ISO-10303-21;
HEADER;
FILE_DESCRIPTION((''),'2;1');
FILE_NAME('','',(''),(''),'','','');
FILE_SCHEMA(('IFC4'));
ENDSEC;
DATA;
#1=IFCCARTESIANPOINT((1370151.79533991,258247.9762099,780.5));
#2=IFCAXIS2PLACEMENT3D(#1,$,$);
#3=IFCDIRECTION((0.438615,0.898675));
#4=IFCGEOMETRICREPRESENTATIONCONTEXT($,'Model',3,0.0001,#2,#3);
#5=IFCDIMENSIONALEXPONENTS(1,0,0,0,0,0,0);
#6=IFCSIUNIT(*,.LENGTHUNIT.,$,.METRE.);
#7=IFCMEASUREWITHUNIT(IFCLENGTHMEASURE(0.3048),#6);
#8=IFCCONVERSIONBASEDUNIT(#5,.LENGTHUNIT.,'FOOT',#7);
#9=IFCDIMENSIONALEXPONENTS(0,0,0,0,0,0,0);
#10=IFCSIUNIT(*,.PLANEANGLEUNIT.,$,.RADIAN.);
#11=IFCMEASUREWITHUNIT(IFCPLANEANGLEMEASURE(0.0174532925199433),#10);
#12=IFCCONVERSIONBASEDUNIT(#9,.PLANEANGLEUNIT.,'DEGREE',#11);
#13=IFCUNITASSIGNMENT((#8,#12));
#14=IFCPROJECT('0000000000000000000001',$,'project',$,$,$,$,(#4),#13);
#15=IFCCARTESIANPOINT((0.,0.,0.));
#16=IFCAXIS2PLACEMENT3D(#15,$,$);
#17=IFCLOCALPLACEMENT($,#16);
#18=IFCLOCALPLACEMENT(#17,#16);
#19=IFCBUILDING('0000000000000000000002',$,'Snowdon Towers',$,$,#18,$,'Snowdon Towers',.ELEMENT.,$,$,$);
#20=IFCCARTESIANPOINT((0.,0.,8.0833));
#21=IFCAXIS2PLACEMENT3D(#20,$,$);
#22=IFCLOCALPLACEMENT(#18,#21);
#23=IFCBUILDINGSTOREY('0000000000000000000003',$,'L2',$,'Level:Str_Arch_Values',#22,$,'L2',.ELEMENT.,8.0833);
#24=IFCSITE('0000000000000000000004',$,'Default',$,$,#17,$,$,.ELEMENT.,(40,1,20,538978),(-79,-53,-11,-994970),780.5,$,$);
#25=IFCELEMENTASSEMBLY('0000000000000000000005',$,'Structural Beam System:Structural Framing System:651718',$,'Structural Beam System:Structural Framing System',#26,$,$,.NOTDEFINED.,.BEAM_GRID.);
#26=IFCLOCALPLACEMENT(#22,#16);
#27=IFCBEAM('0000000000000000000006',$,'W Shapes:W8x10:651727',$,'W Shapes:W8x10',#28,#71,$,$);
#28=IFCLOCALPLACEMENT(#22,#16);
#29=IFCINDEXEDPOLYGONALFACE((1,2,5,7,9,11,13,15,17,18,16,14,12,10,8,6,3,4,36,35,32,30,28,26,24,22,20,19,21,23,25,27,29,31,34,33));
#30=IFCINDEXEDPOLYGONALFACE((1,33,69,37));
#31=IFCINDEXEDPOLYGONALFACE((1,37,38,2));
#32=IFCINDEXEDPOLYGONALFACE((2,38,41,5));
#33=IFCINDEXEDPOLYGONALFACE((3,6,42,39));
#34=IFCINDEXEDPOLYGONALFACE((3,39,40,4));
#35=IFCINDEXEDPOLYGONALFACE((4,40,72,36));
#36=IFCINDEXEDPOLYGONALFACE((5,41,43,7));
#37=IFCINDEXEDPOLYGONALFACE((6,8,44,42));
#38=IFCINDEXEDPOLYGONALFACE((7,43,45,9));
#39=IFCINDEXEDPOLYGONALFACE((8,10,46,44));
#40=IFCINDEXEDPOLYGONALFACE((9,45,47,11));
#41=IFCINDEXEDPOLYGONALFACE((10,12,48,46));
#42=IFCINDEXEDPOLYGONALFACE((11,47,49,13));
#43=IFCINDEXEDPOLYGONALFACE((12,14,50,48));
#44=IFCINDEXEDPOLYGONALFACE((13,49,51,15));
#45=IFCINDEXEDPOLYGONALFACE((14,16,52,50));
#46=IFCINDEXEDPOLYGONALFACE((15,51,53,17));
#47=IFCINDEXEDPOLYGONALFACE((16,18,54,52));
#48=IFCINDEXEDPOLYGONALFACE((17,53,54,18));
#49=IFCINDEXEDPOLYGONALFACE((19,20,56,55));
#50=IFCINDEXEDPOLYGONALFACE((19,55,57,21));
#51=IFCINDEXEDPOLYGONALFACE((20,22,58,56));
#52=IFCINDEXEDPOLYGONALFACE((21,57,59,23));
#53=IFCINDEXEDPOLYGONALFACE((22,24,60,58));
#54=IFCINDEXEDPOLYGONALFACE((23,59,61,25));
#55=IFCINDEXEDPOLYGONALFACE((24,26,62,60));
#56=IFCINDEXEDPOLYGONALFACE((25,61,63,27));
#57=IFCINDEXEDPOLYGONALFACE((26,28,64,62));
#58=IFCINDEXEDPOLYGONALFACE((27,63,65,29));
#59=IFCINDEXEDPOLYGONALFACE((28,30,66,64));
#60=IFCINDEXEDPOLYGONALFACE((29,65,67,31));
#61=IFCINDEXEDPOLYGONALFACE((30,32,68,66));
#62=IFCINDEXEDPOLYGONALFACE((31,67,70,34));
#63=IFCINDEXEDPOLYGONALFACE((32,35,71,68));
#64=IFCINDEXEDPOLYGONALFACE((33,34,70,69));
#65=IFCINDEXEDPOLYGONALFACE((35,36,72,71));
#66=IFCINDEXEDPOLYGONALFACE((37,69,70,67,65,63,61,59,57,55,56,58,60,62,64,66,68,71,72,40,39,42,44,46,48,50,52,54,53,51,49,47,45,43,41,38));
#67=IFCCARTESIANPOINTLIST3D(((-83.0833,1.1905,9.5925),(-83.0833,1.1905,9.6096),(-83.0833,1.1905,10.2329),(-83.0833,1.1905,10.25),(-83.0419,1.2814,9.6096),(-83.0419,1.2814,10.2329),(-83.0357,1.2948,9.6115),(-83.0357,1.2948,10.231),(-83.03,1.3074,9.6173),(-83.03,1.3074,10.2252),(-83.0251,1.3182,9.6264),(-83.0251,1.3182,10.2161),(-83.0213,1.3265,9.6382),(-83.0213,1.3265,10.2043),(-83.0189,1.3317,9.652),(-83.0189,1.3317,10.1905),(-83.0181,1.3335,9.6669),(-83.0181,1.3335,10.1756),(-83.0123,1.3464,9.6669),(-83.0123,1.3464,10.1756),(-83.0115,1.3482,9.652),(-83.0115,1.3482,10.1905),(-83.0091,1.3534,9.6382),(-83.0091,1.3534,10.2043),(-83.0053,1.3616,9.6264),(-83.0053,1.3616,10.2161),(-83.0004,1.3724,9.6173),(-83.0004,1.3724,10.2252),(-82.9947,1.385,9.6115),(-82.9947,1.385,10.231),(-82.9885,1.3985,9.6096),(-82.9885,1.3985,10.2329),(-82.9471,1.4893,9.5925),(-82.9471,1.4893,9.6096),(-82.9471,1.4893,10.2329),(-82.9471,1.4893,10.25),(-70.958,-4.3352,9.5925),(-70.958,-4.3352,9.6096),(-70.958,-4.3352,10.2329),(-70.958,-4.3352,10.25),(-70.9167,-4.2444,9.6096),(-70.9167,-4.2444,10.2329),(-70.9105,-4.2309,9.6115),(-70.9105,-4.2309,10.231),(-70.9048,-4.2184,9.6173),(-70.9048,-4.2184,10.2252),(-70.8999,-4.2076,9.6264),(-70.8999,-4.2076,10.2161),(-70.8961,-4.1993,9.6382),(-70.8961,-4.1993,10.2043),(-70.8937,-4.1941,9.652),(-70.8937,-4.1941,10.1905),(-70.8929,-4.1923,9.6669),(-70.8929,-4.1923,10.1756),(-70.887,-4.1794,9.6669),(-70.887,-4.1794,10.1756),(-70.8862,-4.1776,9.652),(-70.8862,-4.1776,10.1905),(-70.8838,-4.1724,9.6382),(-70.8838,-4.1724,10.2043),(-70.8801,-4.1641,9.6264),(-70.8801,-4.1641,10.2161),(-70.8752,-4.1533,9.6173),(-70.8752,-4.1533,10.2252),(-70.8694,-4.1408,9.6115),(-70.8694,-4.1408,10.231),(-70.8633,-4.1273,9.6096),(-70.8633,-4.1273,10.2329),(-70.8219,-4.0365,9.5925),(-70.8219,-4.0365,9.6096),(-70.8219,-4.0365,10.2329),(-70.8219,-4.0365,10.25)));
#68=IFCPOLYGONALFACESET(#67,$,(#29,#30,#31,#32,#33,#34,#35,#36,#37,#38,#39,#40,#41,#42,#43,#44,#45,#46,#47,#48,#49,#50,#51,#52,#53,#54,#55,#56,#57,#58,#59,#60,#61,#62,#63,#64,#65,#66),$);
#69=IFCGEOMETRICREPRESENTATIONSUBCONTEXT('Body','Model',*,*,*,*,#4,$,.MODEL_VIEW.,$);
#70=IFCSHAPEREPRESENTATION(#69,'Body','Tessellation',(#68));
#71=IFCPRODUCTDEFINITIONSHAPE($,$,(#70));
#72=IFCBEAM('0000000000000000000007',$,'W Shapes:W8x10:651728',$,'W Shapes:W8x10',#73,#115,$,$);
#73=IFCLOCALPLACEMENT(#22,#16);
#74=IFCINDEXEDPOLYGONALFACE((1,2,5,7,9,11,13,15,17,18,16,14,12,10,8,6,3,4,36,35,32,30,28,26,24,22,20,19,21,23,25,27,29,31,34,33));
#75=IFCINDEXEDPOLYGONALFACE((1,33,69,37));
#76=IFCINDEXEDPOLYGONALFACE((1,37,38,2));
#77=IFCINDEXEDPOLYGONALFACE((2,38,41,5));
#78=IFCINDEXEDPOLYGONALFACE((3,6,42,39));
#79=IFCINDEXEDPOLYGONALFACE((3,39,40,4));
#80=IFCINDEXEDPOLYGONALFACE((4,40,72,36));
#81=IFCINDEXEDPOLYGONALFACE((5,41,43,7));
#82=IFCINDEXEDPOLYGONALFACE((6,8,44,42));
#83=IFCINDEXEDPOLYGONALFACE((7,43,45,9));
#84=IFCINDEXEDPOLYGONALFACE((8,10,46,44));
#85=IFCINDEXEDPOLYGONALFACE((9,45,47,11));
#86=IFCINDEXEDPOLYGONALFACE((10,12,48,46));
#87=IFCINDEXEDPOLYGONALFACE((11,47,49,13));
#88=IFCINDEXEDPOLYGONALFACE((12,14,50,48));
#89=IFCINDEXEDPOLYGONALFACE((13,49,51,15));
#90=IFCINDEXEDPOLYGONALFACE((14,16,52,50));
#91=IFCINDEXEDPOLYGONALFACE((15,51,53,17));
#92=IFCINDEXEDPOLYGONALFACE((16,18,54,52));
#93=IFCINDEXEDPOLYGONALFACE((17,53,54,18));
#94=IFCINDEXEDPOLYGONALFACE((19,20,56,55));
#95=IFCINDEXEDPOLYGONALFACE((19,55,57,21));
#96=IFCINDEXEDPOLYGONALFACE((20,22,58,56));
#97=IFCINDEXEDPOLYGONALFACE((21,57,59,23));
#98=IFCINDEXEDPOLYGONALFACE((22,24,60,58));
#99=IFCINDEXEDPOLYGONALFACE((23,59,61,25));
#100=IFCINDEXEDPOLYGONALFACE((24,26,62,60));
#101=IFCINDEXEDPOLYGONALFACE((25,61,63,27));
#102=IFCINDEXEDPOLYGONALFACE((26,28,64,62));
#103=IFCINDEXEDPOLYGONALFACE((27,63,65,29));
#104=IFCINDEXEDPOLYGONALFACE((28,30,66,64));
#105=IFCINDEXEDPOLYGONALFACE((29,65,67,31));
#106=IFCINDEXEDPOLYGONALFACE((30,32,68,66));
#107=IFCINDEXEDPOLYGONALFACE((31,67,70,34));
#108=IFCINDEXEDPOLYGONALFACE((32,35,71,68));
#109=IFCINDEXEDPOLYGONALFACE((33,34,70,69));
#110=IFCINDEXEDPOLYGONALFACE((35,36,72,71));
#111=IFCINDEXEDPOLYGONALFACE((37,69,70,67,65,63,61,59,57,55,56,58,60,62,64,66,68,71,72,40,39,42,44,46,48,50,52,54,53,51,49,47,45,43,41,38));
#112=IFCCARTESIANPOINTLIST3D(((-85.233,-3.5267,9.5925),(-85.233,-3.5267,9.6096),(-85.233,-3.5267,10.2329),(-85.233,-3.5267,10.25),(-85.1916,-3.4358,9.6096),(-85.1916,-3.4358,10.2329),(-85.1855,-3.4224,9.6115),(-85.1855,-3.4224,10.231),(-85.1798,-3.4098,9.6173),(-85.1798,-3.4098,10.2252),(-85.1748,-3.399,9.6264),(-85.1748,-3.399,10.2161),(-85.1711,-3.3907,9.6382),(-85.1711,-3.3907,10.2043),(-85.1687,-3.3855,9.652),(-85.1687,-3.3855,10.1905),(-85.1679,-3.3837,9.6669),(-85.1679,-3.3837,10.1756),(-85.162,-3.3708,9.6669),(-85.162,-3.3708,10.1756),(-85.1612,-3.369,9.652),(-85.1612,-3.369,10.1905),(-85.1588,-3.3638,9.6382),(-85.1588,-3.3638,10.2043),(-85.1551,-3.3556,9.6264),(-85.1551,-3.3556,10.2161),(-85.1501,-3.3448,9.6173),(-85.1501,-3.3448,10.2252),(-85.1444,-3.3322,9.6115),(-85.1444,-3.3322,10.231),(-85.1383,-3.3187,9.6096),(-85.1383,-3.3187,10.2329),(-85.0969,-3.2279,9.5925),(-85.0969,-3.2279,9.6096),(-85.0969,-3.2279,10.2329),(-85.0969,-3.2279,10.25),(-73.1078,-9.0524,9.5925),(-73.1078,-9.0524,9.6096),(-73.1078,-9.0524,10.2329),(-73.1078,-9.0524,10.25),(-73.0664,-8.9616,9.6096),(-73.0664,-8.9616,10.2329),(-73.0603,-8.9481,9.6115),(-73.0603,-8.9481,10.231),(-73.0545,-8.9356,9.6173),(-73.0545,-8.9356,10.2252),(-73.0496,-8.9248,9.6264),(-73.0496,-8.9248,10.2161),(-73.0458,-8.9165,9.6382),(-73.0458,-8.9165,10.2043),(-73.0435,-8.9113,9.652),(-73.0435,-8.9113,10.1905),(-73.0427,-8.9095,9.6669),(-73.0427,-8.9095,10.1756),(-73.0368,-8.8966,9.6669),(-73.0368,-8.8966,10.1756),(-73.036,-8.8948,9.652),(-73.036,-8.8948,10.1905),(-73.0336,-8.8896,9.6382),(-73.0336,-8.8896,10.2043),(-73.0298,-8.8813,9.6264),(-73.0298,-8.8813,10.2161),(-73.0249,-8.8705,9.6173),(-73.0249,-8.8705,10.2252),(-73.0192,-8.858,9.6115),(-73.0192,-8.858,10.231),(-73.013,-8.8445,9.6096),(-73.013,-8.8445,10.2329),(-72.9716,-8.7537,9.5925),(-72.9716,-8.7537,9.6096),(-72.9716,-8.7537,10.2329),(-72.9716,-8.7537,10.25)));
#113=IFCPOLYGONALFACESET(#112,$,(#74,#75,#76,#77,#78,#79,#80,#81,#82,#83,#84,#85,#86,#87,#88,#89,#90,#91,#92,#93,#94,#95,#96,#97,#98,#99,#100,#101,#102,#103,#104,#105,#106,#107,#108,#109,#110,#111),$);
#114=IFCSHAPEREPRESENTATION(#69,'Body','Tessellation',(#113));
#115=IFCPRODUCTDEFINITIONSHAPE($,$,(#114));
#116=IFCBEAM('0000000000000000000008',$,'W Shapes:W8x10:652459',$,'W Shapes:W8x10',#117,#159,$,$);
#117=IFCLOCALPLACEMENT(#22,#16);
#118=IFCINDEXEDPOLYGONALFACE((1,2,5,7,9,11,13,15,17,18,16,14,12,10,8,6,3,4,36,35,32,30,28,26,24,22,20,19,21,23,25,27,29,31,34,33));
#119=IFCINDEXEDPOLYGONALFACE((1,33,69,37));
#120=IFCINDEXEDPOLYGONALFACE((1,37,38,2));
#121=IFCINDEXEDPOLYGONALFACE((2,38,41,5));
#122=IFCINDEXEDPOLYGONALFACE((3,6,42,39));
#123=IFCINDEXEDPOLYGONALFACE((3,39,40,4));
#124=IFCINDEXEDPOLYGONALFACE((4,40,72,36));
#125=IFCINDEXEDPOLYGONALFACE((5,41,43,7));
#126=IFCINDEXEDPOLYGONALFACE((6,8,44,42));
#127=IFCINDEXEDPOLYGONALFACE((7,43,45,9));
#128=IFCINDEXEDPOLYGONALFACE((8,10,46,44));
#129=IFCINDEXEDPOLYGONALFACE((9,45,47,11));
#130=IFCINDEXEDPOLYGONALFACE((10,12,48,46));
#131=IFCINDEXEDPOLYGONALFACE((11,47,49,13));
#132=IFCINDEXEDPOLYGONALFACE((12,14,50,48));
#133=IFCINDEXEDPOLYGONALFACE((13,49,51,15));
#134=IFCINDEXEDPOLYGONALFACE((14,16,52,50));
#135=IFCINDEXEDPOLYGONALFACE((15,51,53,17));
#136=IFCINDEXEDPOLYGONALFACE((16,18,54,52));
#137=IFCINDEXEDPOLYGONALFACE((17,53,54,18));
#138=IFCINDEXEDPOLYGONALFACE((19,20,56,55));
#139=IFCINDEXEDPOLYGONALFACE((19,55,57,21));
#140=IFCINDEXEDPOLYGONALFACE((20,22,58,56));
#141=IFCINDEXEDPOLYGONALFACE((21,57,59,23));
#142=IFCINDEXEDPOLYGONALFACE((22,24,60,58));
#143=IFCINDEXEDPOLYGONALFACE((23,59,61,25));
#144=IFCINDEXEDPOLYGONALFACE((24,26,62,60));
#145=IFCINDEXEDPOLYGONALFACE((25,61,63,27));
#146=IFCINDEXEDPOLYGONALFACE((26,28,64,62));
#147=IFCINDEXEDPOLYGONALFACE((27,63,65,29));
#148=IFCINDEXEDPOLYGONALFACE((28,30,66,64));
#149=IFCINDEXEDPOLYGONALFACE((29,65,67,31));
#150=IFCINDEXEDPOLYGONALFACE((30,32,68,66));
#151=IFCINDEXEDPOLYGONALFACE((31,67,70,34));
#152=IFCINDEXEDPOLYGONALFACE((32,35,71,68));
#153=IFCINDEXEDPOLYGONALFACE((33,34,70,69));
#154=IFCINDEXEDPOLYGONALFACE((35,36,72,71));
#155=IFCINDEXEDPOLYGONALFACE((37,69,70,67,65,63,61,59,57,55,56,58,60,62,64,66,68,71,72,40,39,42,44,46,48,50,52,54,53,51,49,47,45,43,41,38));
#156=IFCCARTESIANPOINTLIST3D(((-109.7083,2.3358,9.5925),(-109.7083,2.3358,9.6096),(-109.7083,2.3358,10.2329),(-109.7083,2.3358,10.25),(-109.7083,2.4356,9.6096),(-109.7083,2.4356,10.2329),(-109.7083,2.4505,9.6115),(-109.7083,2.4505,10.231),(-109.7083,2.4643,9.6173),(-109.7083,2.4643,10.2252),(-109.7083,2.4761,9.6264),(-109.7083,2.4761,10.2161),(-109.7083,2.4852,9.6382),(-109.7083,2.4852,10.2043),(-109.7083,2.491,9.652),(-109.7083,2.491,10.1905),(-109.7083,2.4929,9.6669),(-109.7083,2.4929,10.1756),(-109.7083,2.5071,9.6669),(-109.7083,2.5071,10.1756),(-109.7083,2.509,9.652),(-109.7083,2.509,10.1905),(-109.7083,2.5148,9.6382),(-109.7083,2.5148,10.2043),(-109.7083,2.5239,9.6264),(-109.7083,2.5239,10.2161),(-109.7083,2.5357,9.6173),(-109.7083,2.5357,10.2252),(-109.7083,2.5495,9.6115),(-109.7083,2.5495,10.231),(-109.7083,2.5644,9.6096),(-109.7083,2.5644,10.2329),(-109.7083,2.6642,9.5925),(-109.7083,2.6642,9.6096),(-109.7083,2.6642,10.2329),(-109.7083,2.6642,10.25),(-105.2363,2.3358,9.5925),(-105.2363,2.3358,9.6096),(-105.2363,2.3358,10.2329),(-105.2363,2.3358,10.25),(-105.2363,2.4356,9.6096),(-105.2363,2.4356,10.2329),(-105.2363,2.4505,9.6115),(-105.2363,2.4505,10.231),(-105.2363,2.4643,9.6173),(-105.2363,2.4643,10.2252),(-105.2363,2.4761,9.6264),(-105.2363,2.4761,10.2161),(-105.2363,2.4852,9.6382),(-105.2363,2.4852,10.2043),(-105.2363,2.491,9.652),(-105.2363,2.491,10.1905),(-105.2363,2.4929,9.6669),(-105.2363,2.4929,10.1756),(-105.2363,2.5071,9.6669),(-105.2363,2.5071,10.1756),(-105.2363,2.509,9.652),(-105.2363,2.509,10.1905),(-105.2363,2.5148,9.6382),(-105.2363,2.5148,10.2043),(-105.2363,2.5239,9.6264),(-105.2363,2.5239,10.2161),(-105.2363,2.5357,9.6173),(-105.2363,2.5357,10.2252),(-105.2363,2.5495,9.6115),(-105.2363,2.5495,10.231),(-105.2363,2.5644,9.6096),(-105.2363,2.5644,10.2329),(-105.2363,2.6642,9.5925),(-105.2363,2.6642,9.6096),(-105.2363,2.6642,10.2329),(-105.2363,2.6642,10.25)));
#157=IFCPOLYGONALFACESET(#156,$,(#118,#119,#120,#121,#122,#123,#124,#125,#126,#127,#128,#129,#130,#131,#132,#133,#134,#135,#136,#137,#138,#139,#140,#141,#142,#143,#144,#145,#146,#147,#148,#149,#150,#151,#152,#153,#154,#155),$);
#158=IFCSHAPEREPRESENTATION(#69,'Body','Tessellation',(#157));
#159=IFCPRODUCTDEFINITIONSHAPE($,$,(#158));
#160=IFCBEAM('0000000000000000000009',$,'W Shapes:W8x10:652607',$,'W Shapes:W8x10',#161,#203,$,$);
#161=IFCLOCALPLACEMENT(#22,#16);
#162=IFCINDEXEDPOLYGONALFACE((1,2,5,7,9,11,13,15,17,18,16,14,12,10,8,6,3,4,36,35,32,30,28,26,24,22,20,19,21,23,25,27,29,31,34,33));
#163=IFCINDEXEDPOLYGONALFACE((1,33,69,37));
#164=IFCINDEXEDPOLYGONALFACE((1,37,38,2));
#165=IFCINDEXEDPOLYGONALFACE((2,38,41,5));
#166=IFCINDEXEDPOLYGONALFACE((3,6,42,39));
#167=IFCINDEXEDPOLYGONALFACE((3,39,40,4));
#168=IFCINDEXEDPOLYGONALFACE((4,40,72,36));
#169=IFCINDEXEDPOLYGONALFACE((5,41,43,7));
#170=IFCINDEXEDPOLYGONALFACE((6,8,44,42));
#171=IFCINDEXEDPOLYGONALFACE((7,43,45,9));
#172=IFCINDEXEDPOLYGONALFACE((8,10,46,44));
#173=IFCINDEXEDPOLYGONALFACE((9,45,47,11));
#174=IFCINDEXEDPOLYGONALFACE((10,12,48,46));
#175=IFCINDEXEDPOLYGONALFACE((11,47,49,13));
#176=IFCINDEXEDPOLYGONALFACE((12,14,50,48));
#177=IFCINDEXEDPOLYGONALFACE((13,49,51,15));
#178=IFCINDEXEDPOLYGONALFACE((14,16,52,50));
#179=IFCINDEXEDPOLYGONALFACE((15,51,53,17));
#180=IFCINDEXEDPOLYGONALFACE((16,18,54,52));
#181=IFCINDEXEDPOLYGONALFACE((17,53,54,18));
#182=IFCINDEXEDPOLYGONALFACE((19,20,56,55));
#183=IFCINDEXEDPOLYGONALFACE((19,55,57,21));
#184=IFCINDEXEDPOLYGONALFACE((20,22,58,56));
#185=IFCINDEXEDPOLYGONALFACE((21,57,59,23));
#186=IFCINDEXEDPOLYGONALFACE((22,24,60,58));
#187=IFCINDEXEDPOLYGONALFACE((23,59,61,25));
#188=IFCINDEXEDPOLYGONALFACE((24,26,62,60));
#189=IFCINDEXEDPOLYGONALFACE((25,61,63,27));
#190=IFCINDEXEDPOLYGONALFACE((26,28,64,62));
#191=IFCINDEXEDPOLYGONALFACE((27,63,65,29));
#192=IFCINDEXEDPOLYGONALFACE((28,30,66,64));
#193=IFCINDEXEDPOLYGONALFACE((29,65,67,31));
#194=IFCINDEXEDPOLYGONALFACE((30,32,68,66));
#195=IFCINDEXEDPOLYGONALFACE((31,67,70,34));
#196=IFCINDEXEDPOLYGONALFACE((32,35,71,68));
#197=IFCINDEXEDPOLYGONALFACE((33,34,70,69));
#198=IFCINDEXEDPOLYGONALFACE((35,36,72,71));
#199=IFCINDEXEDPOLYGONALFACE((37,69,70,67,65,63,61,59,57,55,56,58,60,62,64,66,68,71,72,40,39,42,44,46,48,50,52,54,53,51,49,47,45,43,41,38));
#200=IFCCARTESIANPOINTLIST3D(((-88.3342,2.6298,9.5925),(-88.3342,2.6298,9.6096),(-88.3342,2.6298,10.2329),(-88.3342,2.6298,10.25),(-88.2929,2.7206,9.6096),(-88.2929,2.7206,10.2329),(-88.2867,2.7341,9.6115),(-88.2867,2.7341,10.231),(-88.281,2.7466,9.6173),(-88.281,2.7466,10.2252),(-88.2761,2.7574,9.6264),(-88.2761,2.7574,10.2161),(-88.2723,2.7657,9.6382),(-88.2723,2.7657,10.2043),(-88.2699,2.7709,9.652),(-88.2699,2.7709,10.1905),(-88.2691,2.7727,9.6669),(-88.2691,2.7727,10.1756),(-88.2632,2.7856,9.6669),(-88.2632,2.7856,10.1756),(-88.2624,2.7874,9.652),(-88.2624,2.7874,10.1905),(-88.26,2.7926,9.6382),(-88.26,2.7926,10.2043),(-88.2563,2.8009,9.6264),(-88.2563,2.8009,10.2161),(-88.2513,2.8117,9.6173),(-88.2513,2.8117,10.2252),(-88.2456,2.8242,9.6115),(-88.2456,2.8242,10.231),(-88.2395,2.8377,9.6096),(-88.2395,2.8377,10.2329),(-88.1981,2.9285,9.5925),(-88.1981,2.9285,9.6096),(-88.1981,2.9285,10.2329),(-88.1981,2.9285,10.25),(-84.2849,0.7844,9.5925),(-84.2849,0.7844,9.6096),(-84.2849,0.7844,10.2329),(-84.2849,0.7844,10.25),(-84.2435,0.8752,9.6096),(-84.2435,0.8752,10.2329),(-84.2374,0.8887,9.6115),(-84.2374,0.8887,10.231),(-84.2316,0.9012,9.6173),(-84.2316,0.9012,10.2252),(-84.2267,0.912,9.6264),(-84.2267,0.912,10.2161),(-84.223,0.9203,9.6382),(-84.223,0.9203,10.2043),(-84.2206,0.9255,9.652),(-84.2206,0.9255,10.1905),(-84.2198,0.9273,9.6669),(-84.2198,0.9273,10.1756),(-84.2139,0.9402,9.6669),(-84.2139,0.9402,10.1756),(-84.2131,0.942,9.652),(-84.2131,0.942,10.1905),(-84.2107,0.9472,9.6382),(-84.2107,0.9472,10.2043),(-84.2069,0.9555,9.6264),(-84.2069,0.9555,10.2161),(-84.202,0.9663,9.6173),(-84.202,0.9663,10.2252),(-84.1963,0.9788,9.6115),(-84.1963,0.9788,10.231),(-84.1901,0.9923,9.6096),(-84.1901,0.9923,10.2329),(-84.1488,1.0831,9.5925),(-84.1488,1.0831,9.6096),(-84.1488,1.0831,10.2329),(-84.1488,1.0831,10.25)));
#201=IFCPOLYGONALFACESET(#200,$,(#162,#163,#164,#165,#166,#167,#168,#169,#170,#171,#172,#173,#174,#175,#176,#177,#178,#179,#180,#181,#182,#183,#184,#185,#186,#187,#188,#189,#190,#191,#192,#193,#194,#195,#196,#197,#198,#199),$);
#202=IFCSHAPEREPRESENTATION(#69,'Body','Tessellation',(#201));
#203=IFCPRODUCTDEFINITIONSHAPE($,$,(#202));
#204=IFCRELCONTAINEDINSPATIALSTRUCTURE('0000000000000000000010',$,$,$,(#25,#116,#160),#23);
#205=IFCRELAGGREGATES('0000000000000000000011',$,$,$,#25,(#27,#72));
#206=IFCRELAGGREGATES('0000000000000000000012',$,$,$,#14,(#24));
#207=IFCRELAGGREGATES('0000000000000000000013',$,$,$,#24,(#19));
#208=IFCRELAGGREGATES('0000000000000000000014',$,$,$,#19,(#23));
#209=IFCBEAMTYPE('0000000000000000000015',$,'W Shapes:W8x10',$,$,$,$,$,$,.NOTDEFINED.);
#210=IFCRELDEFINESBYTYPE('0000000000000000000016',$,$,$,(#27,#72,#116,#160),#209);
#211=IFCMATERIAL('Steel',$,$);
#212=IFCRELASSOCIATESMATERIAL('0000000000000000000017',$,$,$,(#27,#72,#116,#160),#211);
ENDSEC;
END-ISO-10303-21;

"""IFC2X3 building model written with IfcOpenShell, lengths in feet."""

from ifc_helpers import new_model, entity, si_unit, converted_unit, direction, frame, frame_2d, origin, place, context, subcontext, project, spatial, i_section, extrude, material, type_object, element, aggregate, save


model = new_model("IFC2X3")

# Units and contexts
model_context = context("Model", 3, precision=0.0001, world=frame((1370151.79533991, 258247.9762099, 780.5)), true_north=direction((0.438615, 0.898675)))
body_context = subcontext(model_context, "Body", "Model", "MODEL_VIEW")
ifc_project = project(units=[converted_unit("LENGTHUNIT", "FOOT", entity("IfcLengthMeasure", 0.3048), si_unit("LENGTHUNIT", "METRE"), dimensions=[1, 0, 0, 0, 0, 0, 0]), converted_unit("PLANEANGLEUNIT", "DEGREE", entity("IfcPlaneAngleMeasure", 0.0174532925199433), si_unit("PLANEANGLEUNIT", "RADIAN"), dimensions=[0, 0, 0, 0, 0, 0, 0])], contexts=[model_context])

# Site, building, storey
site_placement = place(None, origin())
site = spatial("IfcSite", under=ifc_project, at=site_placement, Name="Default", CompositionType="ELEMENT", RefLatitude=(40, 1, 20, 538978), RefLongitude=(-79, -53, -11, -994970), RefElevation=780.5)
building_placement = place(site_placement, origin())
building = spatial("IfcBuilding", under=site, at=building_placement, Name="Snowdon Towers", LongName="Snowdon Towers", CompositionType="ELEMENT")
storey_placement = place(building_placement, frame((0.0, 0.0, 8.0833)))
storey = spatial("IfcBuildingStorey", under=building, at=storey_placement, Name="L2", ObjectType="Level:Str_Arch_Values", LongName="L2", CompositionType="ELEMENT", Elevation=8.0833)

# Shared definitions
ifc_material_1 = material(Name="Steel")

# Element assembly, beams
beam_type_1 = type_object("IfcBeamType", Name="W Shapes:W8x10", PredefinedType="NOTDEFINED")
assembly_1_placement = place(storey_placement, origin())
assembly_1 = element("IfcElementAssembly", 1, at=assembly_1_placement, inside=storey, Name="Structural Beam System:Structural Framing System:651718", ObjectType="Structural Beam System:Structural Framing System", AssemblyPlace="NOTDEFINED", PredefinedType="BEAM_GRID")
beam_1_placement = place(assembly_1_placement, frame((-83.4361, 1.5317, 10.25), z_axis=(0.0, 0.0, 1.0), x_axis=(0.909961, -0.414693, 0.0)))
beam_1 = element("IfcBeam", 2, at=beam_1_placement, type_object=beam_type_1, material=ifc_material_1, Name="W Shapes:W8x10:651727", ObjectType="W Shapes:W8x10", context=body_context, shape_type="SweptSolid", body=[
    extrude(i_section(OverallWidth=0.3283, OverallDepth=0.6575, WebThickness=0.0142, FlangeThickness=0.0171, FilletRadius=0.0573, at=frame_2d((0.0, 0.0), x_axis=(0.0, 1.0))), frame((0.4625, 0.0, -0.3288), z_axis=(1.0, 0.0, 0.0), x_axis=(0.0, 0.0, -1.0)), (0.0, 0.0, 1.0), 13.325),
])
beam_2_placement = place(assembly_1_placement, frame((-85.5858, -3.1855, 10.25), z_axis=(0.0, 0.0, 1.0), x_axis=(0.909961, -0.414693, 0.0)))
beam_2 = element("IfcBeam", 3, at=beam_2_placement, type_object=beam_type_1, material=ifc_material_1, Name="W Shapes:W8x10:651728", ObjectType="W Shapes:W8x10", context=body_context, shape_type="SweptSolid", body=[
    extrude(i_section(OverallWidth=0.3283, OverallDepth=0.6575, WebThickness=0.0142, FlangeThickness=0.0171, FilletRadius=0.0573, at=frame_2d((0.0, 0.0), x_axis=(0.0, 1.0))), frame((0.4625, 0.0, -0.3288), z_axis=(1.0, 0.0, 0.0), x_axis=(0.0, 0.0, -1.0)), (0.0, 0.0, 1.0), 13.325),
])
aggregate(assembly_1, [beam_1, beam_2])

# Beams
beam_3_placement = place(storey_placement, frame((-111.0, 2.5, 10.25)))
element("IfcBeam", 4, at=beam_3_placement, inside=storey, type_object=beam_type_1, material=ifc_material_1, Name="W Shapes:W8x10:652459", ObjectType="W Shapes:W8x10", context=body_context, shape_type="SweptSolid", body=[
    extrude(i_section(OverallWidth=0.3283, OverallDepth=0.6575, WebThickness=0.0142, FlangeThickness=0.0171, FilletRadius=0.0573, at=frame_2d((0.0, 0.0), x_axis=(0.0, 1.0))), frame((1.2917, 0.0, -0.3288), z_axis=(1.0, 0.0, 0.0), x_axis=(0.0, 0.0, -1.0)), (0.0, 0.0, 1.0), 4.472),
])
beam_4_placement = place(storey_placement, frame((-83.796, 0.742, 10.25), z_axis=(0.0, 0.0, 1.0), x_axis=(-0.909961, 0.414693, 0.0)))
element("IfcBeam", 5, at=beam_4_placement, inside=storey, type_object=beam_type_1, material=ifc_material_1, Name="W Shapes:W8x10:652607", ObjectType="W Shapes:W8x10", context=body_context, shape_type="SweptSolid", body=[
    extrude(i_section(OverallWidth=0.3283, OverallDepth=0.6575, WebThickness=0.0142, FlangeThickness=0.0171, FilletRadius=0.0573, at=frame_2d((0.0, 0.0), x_axis=(0.0, 1.0))), frame((0.4625, 0.0, -0.3288), z_axis=(1.0, 0.0, 0.0), x_axis=(0.0, 0.0, -1.0)), (0.0, 0.0, 1.0), 4.45),
])

save(model, "model.ifc")
